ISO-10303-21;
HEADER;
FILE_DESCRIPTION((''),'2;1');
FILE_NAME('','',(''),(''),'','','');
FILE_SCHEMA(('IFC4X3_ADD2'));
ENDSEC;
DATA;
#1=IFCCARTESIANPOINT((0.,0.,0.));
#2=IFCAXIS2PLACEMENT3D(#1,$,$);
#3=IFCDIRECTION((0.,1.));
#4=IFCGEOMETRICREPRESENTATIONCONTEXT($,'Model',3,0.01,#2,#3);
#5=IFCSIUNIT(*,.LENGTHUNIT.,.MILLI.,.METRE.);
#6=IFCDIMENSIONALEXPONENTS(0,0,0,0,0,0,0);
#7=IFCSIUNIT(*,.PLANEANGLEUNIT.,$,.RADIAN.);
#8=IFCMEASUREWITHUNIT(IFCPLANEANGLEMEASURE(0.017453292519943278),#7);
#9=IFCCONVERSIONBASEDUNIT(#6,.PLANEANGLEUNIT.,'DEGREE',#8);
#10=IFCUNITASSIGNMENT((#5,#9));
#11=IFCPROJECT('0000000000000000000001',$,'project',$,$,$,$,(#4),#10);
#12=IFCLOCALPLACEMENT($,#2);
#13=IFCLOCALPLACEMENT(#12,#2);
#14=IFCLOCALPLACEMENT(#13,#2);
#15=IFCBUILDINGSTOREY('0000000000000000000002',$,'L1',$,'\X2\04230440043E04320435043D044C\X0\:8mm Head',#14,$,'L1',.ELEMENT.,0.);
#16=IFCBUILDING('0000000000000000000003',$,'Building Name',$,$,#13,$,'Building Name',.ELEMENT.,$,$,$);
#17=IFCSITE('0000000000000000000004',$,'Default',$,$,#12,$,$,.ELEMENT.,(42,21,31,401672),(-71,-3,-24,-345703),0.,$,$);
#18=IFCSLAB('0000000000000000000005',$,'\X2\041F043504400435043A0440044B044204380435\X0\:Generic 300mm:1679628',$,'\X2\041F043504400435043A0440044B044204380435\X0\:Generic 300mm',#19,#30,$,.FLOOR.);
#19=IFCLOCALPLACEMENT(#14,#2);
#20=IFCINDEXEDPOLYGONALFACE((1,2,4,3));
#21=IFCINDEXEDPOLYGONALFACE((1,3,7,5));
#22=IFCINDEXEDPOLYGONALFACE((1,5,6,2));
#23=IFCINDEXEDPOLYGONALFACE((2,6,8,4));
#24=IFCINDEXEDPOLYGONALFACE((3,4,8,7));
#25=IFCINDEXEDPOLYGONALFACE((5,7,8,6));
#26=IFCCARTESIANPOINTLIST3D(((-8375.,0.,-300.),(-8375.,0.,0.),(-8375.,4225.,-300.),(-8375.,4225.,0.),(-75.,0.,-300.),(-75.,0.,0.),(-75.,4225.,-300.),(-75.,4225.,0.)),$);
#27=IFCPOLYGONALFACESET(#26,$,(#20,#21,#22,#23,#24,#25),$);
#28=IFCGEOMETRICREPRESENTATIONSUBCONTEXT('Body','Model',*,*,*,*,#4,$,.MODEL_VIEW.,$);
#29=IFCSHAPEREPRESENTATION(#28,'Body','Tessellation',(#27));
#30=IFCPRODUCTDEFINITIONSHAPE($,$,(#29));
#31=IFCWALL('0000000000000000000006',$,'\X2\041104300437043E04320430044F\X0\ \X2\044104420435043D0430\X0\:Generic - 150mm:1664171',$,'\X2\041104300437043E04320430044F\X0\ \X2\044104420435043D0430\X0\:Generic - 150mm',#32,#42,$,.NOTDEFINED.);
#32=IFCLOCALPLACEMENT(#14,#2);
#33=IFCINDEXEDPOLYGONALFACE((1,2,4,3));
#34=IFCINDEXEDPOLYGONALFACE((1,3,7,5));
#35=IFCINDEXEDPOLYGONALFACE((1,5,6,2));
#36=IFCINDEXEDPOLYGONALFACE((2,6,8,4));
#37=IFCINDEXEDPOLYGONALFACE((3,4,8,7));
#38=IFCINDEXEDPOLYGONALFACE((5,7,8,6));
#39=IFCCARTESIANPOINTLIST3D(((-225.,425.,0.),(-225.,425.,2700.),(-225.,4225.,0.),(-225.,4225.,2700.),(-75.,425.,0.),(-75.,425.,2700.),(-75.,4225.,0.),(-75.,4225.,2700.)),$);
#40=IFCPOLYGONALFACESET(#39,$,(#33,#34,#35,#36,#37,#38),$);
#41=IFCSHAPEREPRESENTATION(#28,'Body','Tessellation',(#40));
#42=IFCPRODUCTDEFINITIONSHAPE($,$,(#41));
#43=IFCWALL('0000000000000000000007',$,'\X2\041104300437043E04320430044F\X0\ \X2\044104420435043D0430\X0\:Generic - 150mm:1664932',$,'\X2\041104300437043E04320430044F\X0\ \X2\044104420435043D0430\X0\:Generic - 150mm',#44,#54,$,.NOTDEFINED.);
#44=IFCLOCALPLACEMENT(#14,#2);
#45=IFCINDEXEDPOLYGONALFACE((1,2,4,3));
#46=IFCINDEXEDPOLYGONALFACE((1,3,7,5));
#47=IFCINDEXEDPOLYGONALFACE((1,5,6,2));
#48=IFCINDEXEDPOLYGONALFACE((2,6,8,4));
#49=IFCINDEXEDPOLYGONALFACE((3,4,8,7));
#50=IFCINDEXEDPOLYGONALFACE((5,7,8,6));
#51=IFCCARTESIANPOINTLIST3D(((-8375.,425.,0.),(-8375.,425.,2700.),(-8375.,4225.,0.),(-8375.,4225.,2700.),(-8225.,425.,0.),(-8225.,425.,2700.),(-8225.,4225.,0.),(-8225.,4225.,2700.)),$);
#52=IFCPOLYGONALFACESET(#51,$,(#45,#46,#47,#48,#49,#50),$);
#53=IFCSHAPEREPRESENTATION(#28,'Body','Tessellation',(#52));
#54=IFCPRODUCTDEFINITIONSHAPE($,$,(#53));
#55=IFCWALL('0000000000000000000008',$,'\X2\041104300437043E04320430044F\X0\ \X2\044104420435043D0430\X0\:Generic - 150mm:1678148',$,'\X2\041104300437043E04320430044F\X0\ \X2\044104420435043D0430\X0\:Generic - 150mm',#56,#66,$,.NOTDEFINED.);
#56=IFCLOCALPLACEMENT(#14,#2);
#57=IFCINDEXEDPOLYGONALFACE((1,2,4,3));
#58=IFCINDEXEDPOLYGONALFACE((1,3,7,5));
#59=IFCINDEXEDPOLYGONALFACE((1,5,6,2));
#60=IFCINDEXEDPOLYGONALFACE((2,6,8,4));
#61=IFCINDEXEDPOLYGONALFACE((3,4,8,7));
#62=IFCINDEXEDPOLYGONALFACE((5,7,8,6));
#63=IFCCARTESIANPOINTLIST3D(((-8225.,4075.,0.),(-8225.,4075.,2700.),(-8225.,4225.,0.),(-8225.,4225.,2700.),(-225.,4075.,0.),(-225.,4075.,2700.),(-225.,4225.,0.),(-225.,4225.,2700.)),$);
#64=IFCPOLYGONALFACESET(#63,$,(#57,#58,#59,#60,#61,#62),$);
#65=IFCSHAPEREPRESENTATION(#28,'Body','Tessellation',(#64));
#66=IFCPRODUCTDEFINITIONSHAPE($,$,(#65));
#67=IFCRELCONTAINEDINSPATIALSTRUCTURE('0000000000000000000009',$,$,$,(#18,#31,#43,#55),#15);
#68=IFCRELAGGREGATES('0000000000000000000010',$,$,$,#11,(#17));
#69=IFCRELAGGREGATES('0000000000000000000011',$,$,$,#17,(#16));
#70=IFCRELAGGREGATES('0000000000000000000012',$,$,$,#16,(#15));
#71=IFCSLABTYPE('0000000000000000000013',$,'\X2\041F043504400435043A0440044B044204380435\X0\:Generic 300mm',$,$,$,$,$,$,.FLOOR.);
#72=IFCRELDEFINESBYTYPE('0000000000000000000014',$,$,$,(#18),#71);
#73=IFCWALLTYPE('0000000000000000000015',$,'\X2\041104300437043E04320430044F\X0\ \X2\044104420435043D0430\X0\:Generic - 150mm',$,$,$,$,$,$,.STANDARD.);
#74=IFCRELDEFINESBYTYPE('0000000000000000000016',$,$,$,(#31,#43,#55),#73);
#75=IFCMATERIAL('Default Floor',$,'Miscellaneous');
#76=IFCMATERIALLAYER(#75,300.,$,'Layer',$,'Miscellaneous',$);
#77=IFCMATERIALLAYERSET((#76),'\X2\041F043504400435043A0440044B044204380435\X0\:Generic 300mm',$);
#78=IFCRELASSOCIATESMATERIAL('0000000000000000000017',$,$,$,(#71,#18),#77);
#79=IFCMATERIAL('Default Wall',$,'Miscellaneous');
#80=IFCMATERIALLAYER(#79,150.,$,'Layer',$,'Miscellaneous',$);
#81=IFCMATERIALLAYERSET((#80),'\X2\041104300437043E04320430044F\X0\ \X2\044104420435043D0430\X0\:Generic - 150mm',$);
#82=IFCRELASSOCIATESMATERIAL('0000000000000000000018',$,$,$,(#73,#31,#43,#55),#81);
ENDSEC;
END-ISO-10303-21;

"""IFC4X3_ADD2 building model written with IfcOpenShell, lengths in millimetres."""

from ifc_helpers import new_model, entity, si_unit, converted_unit, direction, frame, frame_2d, origin, origin_2d_with_axis, place, context, subcontext, project, spatial, rectangle, extrude, material, layer, layer_set, layer_usage, type_object, element, save


model = new_model("IFC4X3_ADD2")

# Units and contexts
model_context = context("Model", 3, precision=0.01, world=origin(), true_north=direction((0.0, 1.0)))
body_context = subcontext(model_context, "Body", "Model", "MODEL_VIEW")
ifc_project = project(units=[si_unit("LENGTHUNIT", "METRE", prefix="MILLI"), converted_unit("PLANEANGLEUNIT", "DEGREE", entity("IfcPlaneAngleMeasure", 0.017453292519943278), si_unit("PLANEANGLEUNIT", "RADIAN"), dimensions=[0, 0, 0, 0, 0, 0, 0])], contexts=[model_context])

# Site, building, storey
site_placement = place(None, origin())
site = spatial("IfcSite", under=ifc_project, at=site_placement, Name="Default", CompositionType="ELEMENT", RefLatitude=(42, 21, 31, 401672), RefLongitude=(-71, -3, -24, -345703), RefElevation=0.0)
building_placement = place(site_placement, origin())
building = spatial("IfcBuilding", under=site, at=building_placement, Name="Building Name", LongName="Building Name", CompositionType="ELEMENT")
storey_placement = place(building_placement, origin())
storey = spatial("IfcBuildingStorey", under=building, at=storey_placement, Name="L1", ObjectType="Уровень:8mm Head", LongName="L1", CompositionType="ELEMENT", Elevation=0.0)

# Slab
ifc_material_1 = material(Name="Default Floor", Category="Miscellaneous")
ifc_layer_1 = layer(ifc_material_1, 300.0, Name="Layer", Category="Miscellaneous")
ifc_layer_set_1 = layer_set([ifc_layer_1], Name="Перекрытие:Generic 300mm")
ifc_layer_usage = layer_usage(ifc_layer_set_1, "AXIS3", "POSITIVE", 0.0)
slab_type = type_object("IfcSlabType", Name="Перекрытие:Generic 300mm", PredefinedType="FLOOR", material=ifc_layer_set_1)
slab_placement = place(storey_placement, origin())
element("IfcSlab", 1, at=slab_placement, inside=storey, type_object=slab_type, material=ifc_layer_usage, Name="Перекрытие:Generic 300mm:1679628", ObjectType="Перекрытие:Generic 300mm", PredefinedType="FLOOR", context=body_context, shape_type="SweptSolid", body=[
    extrude(rectangle(XDim=4225.0, YDim=8300.0, at=origin_2d_with_axis()), frame((-4225.0, 2112.5, 0.0), z_axis=(0.0, 0.0, -1.0), x_axis=(0.0, 1.0, 0.0)), (0.0, 0.0, 1.0), 300.0),
])

# Walls
ifc_material_2 = material(Name="Default Wall", Category="Miscellaneous")
ifc_layer_2 = layer(ifc_material_2, 150.0, Name="Layer", Category="Miscellaneous")
ifc_layer_set_2 = layer_set([ifc_layer_2], Name="Базовая стена:Generic - 150mm")
wall_type = type_object("IfcWallType", Name="Базовая стена:Generic - 150mm", PredefinedType="STANDARD", material=ifc_layer_set_2)
wall_1_placement = place(storey_placement, frame((-150.0, 425.0, 0.0), z_axis=(0.0, 0.0, 1.0), x_axis=(0.0, 1.0, 0.0)))
element("IfcWall", 2, at=wall_1_placement, inside=storey, type_object=wall_type, material=ifc_layer_set_2, Name="Базовая стена:Generic - 150mm:1664171", ObjectType="Базовая стена:Generic - 150mm", PredefinedType="NOTDEFINED", context=body_context, shape_type="SweptSolid", body=[
    extrude(rectangle(XDim=3800.0, YDim=150.0, at=frame_2d((1900.0, 0.0), x_axis=(-1.0, 0.0))), origin(), (0.0, 0.0, 1.0), 2700.0),
])
wall_2_placement = place(storey_placement, frame((-8300.0, 4225.0, 0.0), z_axis=(0.0, 0.0, 1.0), x_axis=(0.0, -1.0, 0.0)))
element("IfcWall", 3, at=wall_2_placement, inside=storey, type_object=wall_type, material=ifc_layer_set_2, Name="Базовая стена:Generic - 150mm:1664932", ObjectType="Базовая стена:Generic - 150mm", PredefinedType="NOTDEFINED", context=body_context, shape_type="SweptSolid", body=[
    extrude(rectangle(XDim=3800.0, YDim=150.0, at=frame_2d((1900.0, 0.0), x_axis=(-1.0, 0.0))), origin(), (0.0, 0.0, 1.0), 2700.0),
])
wall_3_placement = place(storey_placement, frame((-8225.0, 4150.0, 0.0)))
element("IfcWall", 4, at=wall_3_placement, inside=storey, type_object=wall_type, material=ifc_layer_set_2, Name="Базовая стена:Generic - 150mm:1678148", ObjectType="Базовая стена:Generic - 150mm", PredefinedType="NOTDEFINED", context=body_context, shape_type="SweptSolid", body=[
    extrude(rectangle(XDim=8000.0, YDim=150.0, at=frame_2d((4000.0, 0.0), x_axis=(-1.0, 0.0))), origin(), (0.0, 0.0, 1.0), 2700.0),
])

save(model, "model.ifc")
